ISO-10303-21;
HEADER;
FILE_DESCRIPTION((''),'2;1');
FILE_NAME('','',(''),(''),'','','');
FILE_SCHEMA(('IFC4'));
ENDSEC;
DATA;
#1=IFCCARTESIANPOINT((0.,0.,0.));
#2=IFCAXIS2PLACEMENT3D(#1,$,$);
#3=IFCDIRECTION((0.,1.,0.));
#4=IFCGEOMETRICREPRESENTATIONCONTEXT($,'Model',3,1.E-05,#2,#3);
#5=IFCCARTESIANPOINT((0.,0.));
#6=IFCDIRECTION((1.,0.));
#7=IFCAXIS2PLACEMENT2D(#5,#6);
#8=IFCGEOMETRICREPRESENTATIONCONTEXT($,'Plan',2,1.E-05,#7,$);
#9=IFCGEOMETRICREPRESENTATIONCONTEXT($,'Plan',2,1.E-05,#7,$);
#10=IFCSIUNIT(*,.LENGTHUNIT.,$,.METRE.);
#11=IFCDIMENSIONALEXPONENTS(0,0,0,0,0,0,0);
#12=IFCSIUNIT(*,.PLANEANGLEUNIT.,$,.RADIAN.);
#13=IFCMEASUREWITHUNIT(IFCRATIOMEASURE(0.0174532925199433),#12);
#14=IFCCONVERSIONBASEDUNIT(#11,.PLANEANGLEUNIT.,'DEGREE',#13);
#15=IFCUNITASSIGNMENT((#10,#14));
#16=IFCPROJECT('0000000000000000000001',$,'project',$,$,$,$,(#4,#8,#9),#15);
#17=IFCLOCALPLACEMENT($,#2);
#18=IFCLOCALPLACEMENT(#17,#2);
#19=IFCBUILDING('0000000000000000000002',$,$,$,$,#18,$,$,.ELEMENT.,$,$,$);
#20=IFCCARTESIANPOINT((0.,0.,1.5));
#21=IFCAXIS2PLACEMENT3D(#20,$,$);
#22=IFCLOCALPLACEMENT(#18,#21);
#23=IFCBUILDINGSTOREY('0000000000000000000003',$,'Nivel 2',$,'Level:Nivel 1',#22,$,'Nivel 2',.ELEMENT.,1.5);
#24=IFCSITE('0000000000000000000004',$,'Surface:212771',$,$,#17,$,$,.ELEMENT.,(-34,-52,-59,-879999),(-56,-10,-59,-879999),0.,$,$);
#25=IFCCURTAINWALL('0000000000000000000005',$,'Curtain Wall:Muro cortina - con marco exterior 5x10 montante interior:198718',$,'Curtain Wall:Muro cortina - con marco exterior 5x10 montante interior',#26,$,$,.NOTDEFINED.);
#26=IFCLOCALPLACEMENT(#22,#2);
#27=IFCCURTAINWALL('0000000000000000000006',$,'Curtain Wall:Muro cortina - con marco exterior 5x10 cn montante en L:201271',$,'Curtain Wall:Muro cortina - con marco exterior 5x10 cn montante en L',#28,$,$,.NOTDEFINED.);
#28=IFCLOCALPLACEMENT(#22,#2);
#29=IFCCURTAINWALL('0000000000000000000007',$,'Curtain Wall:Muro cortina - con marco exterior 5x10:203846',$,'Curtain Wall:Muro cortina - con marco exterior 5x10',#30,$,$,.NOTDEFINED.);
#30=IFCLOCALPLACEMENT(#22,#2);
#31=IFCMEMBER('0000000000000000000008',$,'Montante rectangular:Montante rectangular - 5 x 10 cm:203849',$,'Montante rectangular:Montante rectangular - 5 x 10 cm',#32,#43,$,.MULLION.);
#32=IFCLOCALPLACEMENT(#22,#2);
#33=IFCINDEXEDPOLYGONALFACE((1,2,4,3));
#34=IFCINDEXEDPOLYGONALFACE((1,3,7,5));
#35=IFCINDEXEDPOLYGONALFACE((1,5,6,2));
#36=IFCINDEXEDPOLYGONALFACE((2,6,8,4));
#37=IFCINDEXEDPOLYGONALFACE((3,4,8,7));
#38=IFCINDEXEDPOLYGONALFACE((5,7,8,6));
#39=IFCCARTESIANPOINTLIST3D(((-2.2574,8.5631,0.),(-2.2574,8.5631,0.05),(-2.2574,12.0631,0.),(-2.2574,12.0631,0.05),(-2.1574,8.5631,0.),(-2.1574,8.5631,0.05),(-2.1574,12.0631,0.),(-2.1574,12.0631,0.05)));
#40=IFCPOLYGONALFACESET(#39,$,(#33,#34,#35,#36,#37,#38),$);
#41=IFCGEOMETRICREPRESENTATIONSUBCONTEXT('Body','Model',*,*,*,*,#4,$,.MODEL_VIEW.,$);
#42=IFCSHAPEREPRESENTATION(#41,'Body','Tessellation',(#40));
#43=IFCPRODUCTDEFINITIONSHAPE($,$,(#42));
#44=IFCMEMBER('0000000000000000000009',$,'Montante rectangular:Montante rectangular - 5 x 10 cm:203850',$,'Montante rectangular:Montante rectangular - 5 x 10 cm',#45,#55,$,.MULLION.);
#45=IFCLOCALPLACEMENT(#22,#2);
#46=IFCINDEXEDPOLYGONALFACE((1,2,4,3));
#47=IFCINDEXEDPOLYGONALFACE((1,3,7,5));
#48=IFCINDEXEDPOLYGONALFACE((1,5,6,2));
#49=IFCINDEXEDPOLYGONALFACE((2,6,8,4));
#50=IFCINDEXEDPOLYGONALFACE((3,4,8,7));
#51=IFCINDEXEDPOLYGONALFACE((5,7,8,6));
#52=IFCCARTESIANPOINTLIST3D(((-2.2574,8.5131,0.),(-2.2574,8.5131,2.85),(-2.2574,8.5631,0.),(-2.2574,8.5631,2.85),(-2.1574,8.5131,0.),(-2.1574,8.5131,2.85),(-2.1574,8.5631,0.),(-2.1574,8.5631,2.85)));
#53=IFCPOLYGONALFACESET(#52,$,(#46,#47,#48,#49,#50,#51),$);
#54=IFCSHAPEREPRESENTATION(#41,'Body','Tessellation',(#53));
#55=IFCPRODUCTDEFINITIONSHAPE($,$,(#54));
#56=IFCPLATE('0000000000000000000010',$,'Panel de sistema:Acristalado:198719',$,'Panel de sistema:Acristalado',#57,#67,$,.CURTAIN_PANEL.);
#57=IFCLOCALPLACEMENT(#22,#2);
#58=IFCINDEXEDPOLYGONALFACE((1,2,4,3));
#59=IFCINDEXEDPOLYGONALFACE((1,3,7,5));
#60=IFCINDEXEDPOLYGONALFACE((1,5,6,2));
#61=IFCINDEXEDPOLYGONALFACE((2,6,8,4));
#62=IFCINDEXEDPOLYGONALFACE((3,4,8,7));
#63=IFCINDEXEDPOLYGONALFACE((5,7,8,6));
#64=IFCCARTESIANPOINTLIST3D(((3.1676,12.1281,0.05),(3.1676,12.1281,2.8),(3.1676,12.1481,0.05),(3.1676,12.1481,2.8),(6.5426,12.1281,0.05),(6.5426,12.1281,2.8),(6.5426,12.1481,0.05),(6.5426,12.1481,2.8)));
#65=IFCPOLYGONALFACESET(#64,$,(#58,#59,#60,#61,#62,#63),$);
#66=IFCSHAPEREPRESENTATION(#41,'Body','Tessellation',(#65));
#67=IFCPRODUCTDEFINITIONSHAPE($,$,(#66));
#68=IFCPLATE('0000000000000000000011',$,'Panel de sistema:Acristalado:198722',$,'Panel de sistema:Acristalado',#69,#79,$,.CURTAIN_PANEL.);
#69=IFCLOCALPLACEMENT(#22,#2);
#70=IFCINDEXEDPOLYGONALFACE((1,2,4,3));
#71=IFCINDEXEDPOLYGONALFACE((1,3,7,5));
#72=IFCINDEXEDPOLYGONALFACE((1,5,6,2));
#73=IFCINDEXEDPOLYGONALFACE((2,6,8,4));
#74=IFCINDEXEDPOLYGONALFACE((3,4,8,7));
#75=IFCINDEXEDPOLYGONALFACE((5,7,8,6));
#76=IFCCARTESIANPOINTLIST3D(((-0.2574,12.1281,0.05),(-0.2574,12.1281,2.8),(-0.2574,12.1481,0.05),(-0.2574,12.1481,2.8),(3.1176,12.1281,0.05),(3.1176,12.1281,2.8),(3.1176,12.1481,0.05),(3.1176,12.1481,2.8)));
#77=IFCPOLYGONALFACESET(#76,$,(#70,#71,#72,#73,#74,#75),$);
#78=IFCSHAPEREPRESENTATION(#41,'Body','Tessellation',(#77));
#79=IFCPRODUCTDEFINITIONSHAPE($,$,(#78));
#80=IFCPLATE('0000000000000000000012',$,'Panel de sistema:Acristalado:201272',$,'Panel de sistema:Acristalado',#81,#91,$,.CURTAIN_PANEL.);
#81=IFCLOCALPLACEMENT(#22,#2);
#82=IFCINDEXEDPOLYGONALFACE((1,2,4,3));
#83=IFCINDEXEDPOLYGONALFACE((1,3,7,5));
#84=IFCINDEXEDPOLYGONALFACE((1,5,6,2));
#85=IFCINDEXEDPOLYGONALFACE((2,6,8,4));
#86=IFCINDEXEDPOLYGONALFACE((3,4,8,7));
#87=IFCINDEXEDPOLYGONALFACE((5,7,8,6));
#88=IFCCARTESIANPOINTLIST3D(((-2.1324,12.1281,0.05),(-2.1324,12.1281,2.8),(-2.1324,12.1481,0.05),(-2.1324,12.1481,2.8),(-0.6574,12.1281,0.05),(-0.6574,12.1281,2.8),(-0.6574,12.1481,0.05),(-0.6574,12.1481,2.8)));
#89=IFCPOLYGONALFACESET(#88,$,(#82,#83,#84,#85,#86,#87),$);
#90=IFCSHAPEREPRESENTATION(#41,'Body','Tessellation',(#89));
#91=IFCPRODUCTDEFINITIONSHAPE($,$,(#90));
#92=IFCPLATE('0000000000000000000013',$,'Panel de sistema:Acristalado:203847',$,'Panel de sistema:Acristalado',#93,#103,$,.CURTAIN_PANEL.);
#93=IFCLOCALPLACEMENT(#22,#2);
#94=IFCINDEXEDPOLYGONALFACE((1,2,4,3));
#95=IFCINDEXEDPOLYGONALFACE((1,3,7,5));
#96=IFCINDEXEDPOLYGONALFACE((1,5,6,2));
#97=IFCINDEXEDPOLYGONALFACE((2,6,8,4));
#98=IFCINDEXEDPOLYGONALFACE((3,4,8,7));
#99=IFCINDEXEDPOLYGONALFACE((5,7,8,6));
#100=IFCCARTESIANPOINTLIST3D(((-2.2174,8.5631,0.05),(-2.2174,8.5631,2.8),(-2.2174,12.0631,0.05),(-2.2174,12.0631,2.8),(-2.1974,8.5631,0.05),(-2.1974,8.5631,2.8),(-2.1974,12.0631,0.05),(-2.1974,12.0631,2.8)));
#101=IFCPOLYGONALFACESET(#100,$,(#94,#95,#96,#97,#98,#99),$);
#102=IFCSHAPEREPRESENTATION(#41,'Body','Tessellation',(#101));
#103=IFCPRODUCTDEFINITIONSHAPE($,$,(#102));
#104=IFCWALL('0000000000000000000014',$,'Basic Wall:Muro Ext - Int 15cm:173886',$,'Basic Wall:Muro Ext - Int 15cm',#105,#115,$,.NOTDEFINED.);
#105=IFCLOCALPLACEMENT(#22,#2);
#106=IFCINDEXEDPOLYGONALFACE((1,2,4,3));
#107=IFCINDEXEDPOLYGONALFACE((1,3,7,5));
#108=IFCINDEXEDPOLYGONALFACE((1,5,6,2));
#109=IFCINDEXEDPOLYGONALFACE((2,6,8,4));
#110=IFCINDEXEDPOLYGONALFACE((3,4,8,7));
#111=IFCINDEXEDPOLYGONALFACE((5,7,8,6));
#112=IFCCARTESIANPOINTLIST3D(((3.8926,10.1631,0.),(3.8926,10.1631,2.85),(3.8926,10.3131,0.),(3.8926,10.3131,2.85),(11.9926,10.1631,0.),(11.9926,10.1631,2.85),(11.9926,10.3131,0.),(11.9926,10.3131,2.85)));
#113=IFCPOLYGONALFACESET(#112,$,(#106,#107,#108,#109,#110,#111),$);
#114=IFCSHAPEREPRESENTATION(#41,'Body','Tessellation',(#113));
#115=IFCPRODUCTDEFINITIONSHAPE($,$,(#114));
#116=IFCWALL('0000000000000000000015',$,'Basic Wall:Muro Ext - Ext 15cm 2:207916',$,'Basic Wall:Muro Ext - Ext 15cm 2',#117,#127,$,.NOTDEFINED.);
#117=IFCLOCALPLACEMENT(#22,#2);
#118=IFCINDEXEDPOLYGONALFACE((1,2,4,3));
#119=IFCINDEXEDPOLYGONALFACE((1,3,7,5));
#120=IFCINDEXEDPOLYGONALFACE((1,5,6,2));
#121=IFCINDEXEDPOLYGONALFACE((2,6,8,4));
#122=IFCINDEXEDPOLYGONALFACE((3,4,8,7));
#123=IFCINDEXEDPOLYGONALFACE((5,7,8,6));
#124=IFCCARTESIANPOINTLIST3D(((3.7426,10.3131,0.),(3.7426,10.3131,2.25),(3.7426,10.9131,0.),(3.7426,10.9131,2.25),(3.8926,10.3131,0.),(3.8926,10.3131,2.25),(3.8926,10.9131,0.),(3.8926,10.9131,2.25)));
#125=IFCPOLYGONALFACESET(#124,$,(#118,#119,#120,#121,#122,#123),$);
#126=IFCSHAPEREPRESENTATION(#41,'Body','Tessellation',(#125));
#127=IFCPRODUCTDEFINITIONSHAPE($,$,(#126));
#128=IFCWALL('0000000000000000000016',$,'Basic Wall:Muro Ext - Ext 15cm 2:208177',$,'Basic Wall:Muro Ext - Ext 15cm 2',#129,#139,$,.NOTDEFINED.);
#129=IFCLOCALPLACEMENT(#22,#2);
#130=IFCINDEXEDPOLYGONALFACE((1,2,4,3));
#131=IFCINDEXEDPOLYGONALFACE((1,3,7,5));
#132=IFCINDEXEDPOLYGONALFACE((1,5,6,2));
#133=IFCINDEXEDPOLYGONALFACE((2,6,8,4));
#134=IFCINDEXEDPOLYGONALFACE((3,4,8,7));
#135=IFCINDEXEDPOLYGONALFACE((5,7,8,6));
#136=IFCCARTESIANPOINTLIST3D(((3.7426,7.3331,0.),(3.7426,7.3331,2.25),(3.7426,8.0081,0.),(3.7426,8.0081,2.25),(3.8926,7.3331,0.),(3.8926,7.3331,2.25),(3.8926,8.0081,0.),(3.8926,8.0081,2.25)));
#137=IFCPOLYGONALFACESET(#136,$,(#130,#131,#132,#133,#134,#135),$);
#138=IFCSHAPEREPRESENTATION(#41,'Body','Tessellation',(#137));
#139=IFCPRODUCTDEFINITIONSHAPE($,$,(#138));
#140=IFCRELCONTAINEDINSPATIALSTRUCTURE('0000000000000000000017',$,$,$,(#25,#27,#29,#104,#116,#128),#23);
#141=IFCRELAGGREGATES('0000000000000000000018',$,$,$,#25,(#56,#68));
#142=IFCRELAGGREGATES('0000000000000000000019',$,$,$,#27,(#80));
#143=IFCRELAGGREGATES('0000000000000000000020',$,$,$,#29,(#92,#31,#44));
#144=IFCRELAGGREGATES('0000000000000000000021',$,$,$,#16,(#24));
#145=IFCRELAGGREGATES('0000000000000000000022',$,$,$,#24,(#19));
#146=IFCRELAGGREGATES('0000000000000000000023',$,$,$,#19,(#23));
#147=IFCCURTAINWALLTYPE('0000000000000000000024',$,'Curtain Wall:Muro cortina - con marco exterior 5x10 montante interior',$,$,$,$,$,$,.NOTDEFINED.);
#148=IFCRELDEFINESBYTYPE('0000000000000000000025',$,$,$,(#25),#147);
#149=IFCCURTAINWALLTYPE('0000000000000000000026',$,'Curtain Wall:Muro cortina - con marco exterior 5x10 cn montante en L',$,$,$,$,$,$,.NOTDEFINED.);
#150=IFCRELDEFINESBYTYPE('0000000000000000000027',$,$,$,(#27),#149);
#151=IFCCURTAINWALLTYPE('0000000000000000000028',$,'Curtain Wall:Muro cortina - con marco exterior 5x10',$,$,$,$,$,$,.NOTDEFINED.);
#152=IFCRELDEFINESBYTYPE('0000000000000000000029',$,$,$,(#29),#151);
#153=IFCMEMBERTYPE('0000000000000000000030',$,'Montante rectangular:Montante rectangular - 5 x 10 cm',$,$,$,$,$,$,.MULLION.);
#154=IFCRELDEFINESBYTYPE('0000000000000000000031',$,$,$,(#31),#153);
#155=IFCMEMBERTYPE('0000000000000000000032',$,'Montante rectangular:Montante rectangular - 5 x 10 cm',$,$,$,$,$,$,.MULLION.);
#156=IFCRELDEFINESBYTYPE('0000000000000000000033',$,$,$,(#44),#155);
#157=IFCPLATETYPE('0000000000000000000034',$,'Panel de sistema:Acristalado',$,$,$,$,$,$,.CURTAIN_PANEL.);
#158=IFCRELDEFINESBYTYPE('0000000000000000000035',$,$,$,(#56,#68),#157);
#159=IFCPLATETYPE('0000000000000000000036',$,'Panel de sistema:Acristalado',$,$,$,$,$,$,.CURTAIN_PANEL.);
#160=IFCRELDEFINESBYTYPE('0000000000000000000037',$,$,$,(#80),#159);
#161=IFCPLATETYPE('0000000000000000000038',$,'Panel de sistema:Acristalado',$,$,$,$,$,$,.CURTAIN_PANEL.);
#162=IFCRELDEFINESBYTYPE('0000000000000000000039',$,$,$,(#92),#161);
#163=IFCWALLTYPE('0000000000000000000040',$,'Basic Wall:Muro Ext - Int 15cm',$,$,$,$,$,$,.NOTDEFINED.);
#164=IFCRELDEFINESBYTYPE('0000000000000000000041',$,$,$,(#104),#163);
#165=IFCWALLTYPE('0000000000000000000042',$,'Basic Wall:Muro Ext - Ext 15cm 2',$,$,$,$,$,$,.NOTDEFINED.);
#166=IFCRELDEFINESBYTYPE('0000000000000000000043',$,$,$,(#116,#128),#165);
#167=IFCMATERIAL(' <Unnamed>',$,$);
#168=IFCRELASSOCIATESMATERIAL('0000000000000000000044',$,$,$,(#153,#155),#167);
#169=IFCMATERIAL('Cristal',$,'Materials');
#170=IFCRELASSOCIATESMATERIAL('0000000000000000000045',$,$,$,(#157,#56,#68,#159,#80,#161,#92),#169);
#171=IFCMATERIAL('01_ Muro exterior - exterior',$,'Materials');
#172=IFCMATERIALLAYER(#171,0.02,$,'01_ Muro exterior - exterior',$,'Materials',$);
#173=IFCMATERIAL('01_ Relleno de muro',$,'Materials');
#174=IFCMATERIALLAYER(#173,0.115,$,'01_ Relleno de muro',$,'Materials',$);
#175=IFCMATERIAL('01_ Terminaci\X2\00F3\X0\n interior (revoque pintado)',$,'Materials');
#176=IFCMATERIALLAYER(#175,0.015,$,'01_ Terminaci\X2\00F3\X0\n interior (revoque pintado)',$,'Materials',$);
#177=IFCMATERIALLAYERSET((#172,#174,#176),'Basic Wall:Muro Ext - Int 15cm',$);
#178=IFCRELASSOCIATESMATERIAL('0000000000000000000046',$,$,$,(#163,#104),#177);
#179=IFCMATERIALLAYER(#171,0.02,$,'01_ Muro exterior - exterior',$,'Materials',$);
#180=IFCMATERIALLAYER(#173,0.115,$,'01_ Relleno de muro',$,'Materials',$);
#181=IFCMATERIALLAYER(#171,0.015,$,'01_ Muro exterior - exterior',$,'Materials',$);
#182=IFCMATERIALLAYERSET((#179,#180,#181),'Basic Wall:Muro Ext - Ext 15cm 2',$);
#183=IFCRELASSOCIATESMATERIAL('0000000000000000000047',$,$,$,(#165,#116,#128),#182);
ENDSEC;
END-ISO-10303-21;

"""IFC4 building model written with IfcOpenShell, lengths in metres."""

from ifc_helpers import new_model, entity, si_unit, converted_unit, direction, frame, origin, origin_2d_with_axis, place, context, subcontext, project, spatial, polyline, indexed_curve, outline, extrude, shape, source, transform, mapped, material, layer, layer_set, type_object, type_shapes, element, aggregate, save


model = new_model("IFC4")

# Units and contexts
model_context = context("Model", 3, precision=1e-05, world=origin(), true_north=direction((0.0, 1.0, 0.0)))
plan_context_1 = context("Plan", 2, precision=1e-05, world=origin_2d_with_axis())
plan_context_2 = context("Plan", 2, precision=1e-05, world=origin_2d_with_axis())
body_context = subcontext(model_context, "Body", "Model", "MODEL_VIEW")
footprint_context = subcontext(model_context, "FootPrint", "Model", "MODEL_VIEW")
ifc_project = project(units=[si_unit("LENGTHUNIT", "METRE"), converted_unit("PLANEANGLEUNIT", "DEGREE", entity("IfcRatioMeasure", 0.0174532925199433), si_unit("PLANEANGLEUNIT", "RADIAN"), dimensions=[0, 0, 0, 0, 0, 0, 0])], contexts=[model_context, plan_context_1, plan_context_2])

# Site, building, storey
site_placement = place(None, origin())
site = spatial("IfcSite", under=ifc_project, at=site_placement, Name="Surface:212771", CompositionType="ELEMENT", RefLatitude=(-34, -52, -59, -879999), RefLongitude=(-56, -10, -59, -879999), RefElevation=0.0)
building_placement = place(site_placement, origin())
building = spatial("IfcBuilding", under=site, at=building_placement, CompositionType="ELEMENT")
storey_placement = place(building_placement, frame((0.0, 0.0, 1.5)))
storey = spatial("IfcBuildingStorey", under=building, at=storey_placement, Name="Nivel 2", ObjectType="Level:Nivel 1", LongName="Nivel 2", CompositionType="ELEMENT", Elevation=1.5)

# Curtain walls, members
curtain_wall_type_1 = type_object("IfcCurtainWallType", Name="Curtain Wall:Muro cortina - con marco exterior 5x10 montante interior", PredefinedType="NOTDEFINED")
curtain_wall_1_placement = place(storey_placement, frame((0.0, 0.0, -1.5)))
curtain_wall_1 = element("IfcCurtainWall", 1, at=curtain_wall_1_placement, inside=storey, type_object=curtain_wall_type_1, Name="Curtain Wall:Muro cortina - con marco exterior 5x10 montante interior:198718", ObjectType="Curtain Wall:Muro cortina - con marco exterior 5x10 montante interior", PredefinedType="NOTDEFINED")
ifc_material_1 = material(Name=" <Unnamed>")
curtain_wall_type_2 = type_object("IfcCurtainWallType", Name="Curtain Wall:Muro cortina - con marco exterior 5x10 cn montante en L", PredefinedType="NOTDEFINED")
curtain_wall_2_placement = place(storey_placement, frame((0.0, 0.0, -1.5)))
curtain_wall_2 = element("IfcCurtainWall", 2, at=curtain_wall_2_placement, inside=storey, type_object=curtain_wall_type_2, Name="Curtain Wall:Muro cortina - con marco exterior 5x10 cn montante en L:201271", ObjectType="Curtain Wall:Muro cortina - con marco exterior 5x10 cn montante en L", PredefinedType="NOTDEFINED")
curtain_wall_type_3 = type_object("IfcCurtainWallType", Name="Curtain Wall:Muro cortina - con marco exterior 5x10", PredefinedType="NOTDEFINED")
curtain_wall_3_placement = place(storey_placement, frame((0.0, 0.0, -1.5)))
curtain_wall_3 = element("IfcCurtainWall", 3, at=curtain_wall_3_placement, inside=storey, type_object=curtain_wall_type_3, Name="Curtain Wall:Muro cortina - con marco exterior 5x10:203846", ObjectType="Curtain Wall:Muro cortina - con marco exterior 5x10", PredefinedType="NOTDEFINED")
member_type_1 = type_object("IfcMemberType", Name="Montante rectangular:Montante rectangular - 5 x 10 cm", PredefinedType="MULLION", material=ifc_material_1)
shared_shape_1 = source(origin(), body_context, "Body", "SweptSolid", [
    extrude(outline(indexed_curve([(-0.05, -0.025), (0.05, -0.025), (0.05, 0.025), (-0.05, 0.025), (-0.05, -0.025)], self_intersect=False)), frame((-0.025, 0.0, -3.5), z_axis=(0.0, 0.0, 1.0), x_axis=(0.0, -1.0, 0.0)), (0.0, 0.0, 1.0), 3.5),
])
type_shapes(member_type_1, [shared_shape_1])
member_1_placement = place(storey_placement, frame((-2.2074, 12.0631, 0.0), z_axis=(0.0, 1.0, 0.0), x_axis=(0.0, 0.0, -1.0)))
member_1 = element("IfcMember", 4, at=member_1_placement, type_object=member_type_1, Name="Montante rectangular:Montante rectangular - 5 x 10 cm:203849", ObjectType="Montante rectangular:Montante rectangular - 5 x 10 cm", PredefinedType="MULLION", context=body_context, shape_type="MappedRepresentation", body=[
    mapped(shared_shape_1, transform((0.0, 0.0, 0.0), scale=1.0)),
])
member_type_2 = type_object("IfcMemberType", Name="Montante rectangular:Montante rectangular - 5 x 10 cm", PredefinedType="MULLION", material=ifc_material_1)
shared_shape_2 = source(origin(), body_context, "Body", "SweptSolid", [
    extrude(outline(indexed_curve([(-0.05, -0.025), (0.05, -0.025), (0.05, 0.025), (-0.05, 0.025), (-0.05, -0.025)], self_intersect=False)), frame((-0.025, 0.0, -2.85), z_axis=(0.0, 0.0, 1.0), x_axis=(0.0, -1.0, 0.0)), (0.0, 0.0, 1.0), 2.85),
])
type_shapes(member_type_2, [shared_shape_2])
member_2_placement = place(storey_placement, frame((-2.2074, 8.5131, 0.0), z_axis=(0.0, 0.0, -1.0), x_axis=(0.0, -1.0, 0.0)))
member_2 = element("IfcMember", 5, at=member_2_placement, type_object=member_type_2, Name="Montante rectangular:Montante rectangular - 5 x 10 cm:203850", ObjectType="Montante rectangular:Montante rectangular - 5 x 10 cm", PredefinedType="MULLION", context=body_context, shape_type="MappedRepresentation", body=[
    mapped(shared_shape_2, transform((0.0, 0.0, 0.0), scale=1.0)),
])

# Plates
ifc_material_2 = material(Name="Cristal", Category="Materials")
plate_type_1 = type_object("IfcPlateType", Name="Panel de sistema:Acristalado", PredefinedType="CURTAIN_PANEL", material=ifc_material_2)
shared_shape_3 = source(origin(), body_context, "Body", "SweptSolid", [
    extrude(outline(indexed_curve([(-0.01, -1.6875), (0.01, -1.6875), (0.01, 1.6875), (-0.01, 1.6875), (-0.01, -1.6875)], self_intersect=False)), frame((0.0, 0.0, 0.0), z_axis=(0.0, 0.0, 1.0), x_axis=(0.0, 1.0, 0.0)), (0.0, 0.0, 1.0), 2.75),
])
shared_shape_4 = source(origin(), footprint_context, "FootPrint", "Curve2D", [
    entity("IfcIndexedPolyCurve", entity("IfcCartesianPointList2D", [[1.6875, -0.01], [1.6875, 0.01], [-1.6875, 0.01], [-1.6875, -0.01], [1.6875, -0.01]]), None, False),
])
type_shapes(plate_type_1, [shared_shape_3, shared_shape_4])
plate_1_placement = place(curtain_wall_1_placement, frame((4.8551, 12.1381, 1.55), z_axis=(0.0, 0.0, 1.0), x_axis=(-1.0, 0.0, 0.0)))
plate_1 = element("IfcPlate", 6, at=plate_1_placement, type_object=plate_type_1, material=ifc_material_2, Name="Panel de sistema:Acristalado:198719", ObjectType="Panel de sistema:Acristalado", PredefinedType="CURTAIN_PANEL", shapes=[
    shape(body_context, "Body", "MappedRepresentation", [mapped(shared_shape_3, transform((0.0, 0.0, 0.0), scale=1.0))]),
    shape(body_context, "Body", "MappedRepresentation", [mapped(shared_shape_4, transform((0.0, 0.0, 0.0), scale=1.0))]),
])
plate_2_placement = place(curtain_wall_1_placement, frame((1.4301, 12.1381, 1.55), z_axis=(0.0, 0.0, 1.0), x_axis=(-1.0, 0.0, 0.0)))
plate_2 = element("IfcPlate", 7, at=plate_2_placement, type_object=plate_type_1, material=ifc_material_2, Name="Panel de sistema:Acristalado:198722", ObjectType="Panel de sistema:Acristalado", PredefinedType="CURTAIN_PANEL", shapes=[
    shape(body_context, "Body", "MappedRepresentation", [mapped(shared_shape_3, transform((0.0, 0.0, 0.0), scale=1.0))]),
    shape(body_context, "Body", "MappedRepresentation", [mapped(shared_shape_4, transform((0.0, 0.0, 0.0), scale=1.0))]),
])
aggregate(curtain_wall_1, [plate_1, plate_2])
plate_type_2 = type_object("IfcPlateType", Name="Panel de sistema:Acristalado", PredefinedType="CURTAIN_PANEL", material=ifc_material_2)
shared_shape_5 = source(origin(), body_context, "Body", "SweptSolid", [
    extrude(outline(polyline([(-0.7375, -0.01), (0.7375, -0.01), (0.7375, 0.01), (-0.7375, 0.01), (-0.7375, -0.01)])), frame((0.0, 0.0, 0.0), z_axis=(0.0, 0.0, -1.0), x_axis=(-1.0, 0.0, 0.0)), (0.0, 0.0, -1.0), 2.75),
])
shared_shape_6 = source(origin(), footprint_context, "FootPrint", "Curve2D", [
    entity("IfcIndexedPolyCurve", entity("IfcCartesianPointList2D", [[0.7375, -0.01], [0.7375, 0.01], [-0.7375, 0.01], [-0.7375, -0.01], [0.7375, -0.01]]), None, False),
])
type_shapes(plate_type_2, [shared_shape_5, shared_shape_6])
plate_3_placement = place(curtain_wall_2_placement, frame((-1.3949, 12.1381, 1.55), z_axis=(0.0, 0.0, 1.0), x_axis=(-1.0, 0.0, 0.0)))
plate_3 = element("IfcPlate", 8, at=plate_3_placement, type_object=plate_type_2, material=ifc_material_2, Name="Panel de sistema:Acristalado:201272", ObjectType="Panel de sistema:Acristalado", PredefinedType="CURTAIN_PANEL", shapes=[
    shape(body_context, "Body", "MappedRepresentation", [mapped(shared_shape_5, transform((0.0, 0.0, 0.0), scale=1.0))]),
    shape(body_context, "Body", "MappedRepresentation", [mapped(shared_shape_6, transform((0.0, 0.0, 0.0), scale=1.0))]),
])
aggregate(curtain_wall_2, [plate_3])
plate_type_3 = type_object("IfcPlateType", Name="Panel de sistema:Acristalado", PredefinedType="CURTAIN_PANEL", material=ifc_material_2)
shared_shape_7 = source(origin(), body_context, "Body", "SweptSolid", [
    extrude(outline(indexed_curve([(-0.01, -1.75), (0.01, -1.75), (0.01, 1.75), (-0.01, 1.75), (-0.01, -1.75)], self_intersect=False)), frame((0.0, 0.0, 0.0), z_axis=(0.0, 0.0, 1.0), x_axis=(0.0, 1.0, 0.0)), (0.0, 0.0, 1.0), 2.75),
])
shared_shape_8 = source(origin(), footprint_context, "FootPrint", "Curve2D", [
    entity("IfcIndexedPolyCurve", entity("IfcCartesianPointList2D", [[1.75, -0.01], [1.75, 0.01], [-1.75, 0.01], [-1.75, -0.01], [1.75, -0.01]]), None, False),
])
type_shapes(plate_type_3, [shared_shape_7, shared_shape_8])
plate_4_placement = place(curtain_wall_3_placement, frame((-2.2074, 10.3131, 1.55), z_axis=(0.0, 0.0, 1.0), x_axis=(0.0, -1.0, 0.0)))
plate_4 = element("IfcPlate", 9, at=plate_4_placement, type_object=plate_type_3, material=ifc_material_2, Name="Panel de sistema:Acristalado:203847", ObjectType="Panel de sistema:Acristalado", PredefinedType="CURTAIN_PANEL", shapes=[
    shape(body_context, "Body", "MappedRepresentation", [mapped(shared_shape_7, transform((0.0, 0.0, 0.0), scale=1.0))]),
    shape(body_context, "Body", "MappedRepresentation", [mapped(shared_shape_8, transform((0.0, 0.0, 0.0), scale=1.0))]),
])
aggregate(curtain_wall_3, [plate_4, member_1, member_2])

# Walls
ifc_material_3 = material(Name="01_ Muro exterior - exterior", Category="Materials")
ifc_layer_1 = layer(ifc_material_3, 0.02, Name="01_ Muro exterior - exterior", Category="Materials")
ifc_material_4 = material(Name="01_ Relleno de muro", Category="Materials")
ifc_layer_2 = layer(ifc_material_4, 0.115, Name="01_ Relleno de muro", Category="Materials")
ifc_material_5 = material(Name="01_ Terminación interior (revoque pintado)", Category="Materials")
ifc_layer_3 = layer(ifc_material_5, 0.015, Name="01_ Terminación interior (revoque pintado)", Category="Materials")
ifc_layer_set_1 = layer_set([ifc_layer_1, ifc_layer_2, ifc_layer_3], Name="Basic Wall:Muro Ext - Int 15cm")
wall_type_1 = type_object("IfcWallType", Name="Basic Wall:Muro Ext - Int 15cm", PredefinedType="NOTDEFINED", material=ifc_layer_set_1)
wall_1_placement = place(storey_placement, frame((3.8926, 10.2381, 0.0)))
element("IfcWall", 10, at=wall_1_placement, inside=storey, type_object=wall_type_1, material=ifc_layer_set_1, Name="Basic Wall:Muro Ext - Int 15cm:173886", ObjectType="Basic Wall:Muro Ext - Int 15cm", PredefinedType="NOTDEFINED", context=body_context, shape_type="SweptSolid", body=[
    extrude(outline(indexed_curve([(8.1, 0.075), (0.0, 0.075), (0.0, -0.075), (8.1, -0.075), (8.1, 0.075)], self_intersect=False)), origin(), (0.0, 0.0, 1.0), 2.85),
])
ifc_layer_4 = layer(ifc_material_3, 0.02, Name="01_ Muro exterior - exterior", Category="Materials")
ifc_layer_5 = layer(ifc_material_4, 0.115, Name="01_ Relleno de muro", Category="Materials")
ifc_layer_6 = layer(ifc_material_3, 0.015, Name="01_ Muro exterior - exterior", Category="Materials")
ifc_layer_set_2 = layer_set([ifc_layer_4, ifc_layer_5, ifc_layer_6], Name="Basic Wall:Muro Ext - Ext 15cm 2")
wall_type_2 = type_object("IfcWallType", Name="Basic Wall:Muro Ext - Ext 15cm 2", PredefinedType="NOTDEFINED", material=ifc_layer_set_2)
wall_2_placement = place(storey_placement, frame((3.8176, 10.3131, 0.0), z_axis=(0.0, 0.0, 1.0), x_axis=(0.0, 1.0, 0.0)))
element("IfcWall", 11, at=wall_2_placement, inside=storey, type_object=wall_type_2, material=ifc_layer_set_2, Name="Basic Wall:Muro Ext - Ext 15cm 2:207916", ObjectType="Basic Wall:Muro Ext - Ext 15cm 2", PredefinedType="NOTDEFINED", context=body_context, shape_type="SweptSolid", body=[
    extrude(outline(indexed_curve([(0.6, 0.075), (0.0, 0.075), (0.0, -0.075), (0.6, -0.075), (0.6, 0.075)], self_intersect=False)), origin(), (0.0, 0.0, 1.0), 2.25),
])
wall_3_placement = place(storey_placement, frame((3.8176, 8.0081, 0.0), z_axis=(0.0, 0.0, 1.0), x_axis=(0.0, -1.0, 0.0)))
element("IfcWall", 12, at=wall_3_placement, inside=storey, type_object=wall_type_2, material=ifc_layer_set_2, Name="Basic Wall:Muro Ext - Ext 15cm 2:208177", ObjectType="Basic Wall:Muro Ext - Ext 15cm 2", PredefinedType="NOTDEFINED", context=body_context, shape_type="SweptSolid", body=[
    extrude(outline(indexed_curve([(0.675, 0.075), (0.0, 0.075), (0.0, -0.075), (0.675, -0.075), (0.675, 0.075)], self_intersect=False)), origin(), (0.0, 0.0, 1.0), 2.25),
])

save(model, "model.ifc")
